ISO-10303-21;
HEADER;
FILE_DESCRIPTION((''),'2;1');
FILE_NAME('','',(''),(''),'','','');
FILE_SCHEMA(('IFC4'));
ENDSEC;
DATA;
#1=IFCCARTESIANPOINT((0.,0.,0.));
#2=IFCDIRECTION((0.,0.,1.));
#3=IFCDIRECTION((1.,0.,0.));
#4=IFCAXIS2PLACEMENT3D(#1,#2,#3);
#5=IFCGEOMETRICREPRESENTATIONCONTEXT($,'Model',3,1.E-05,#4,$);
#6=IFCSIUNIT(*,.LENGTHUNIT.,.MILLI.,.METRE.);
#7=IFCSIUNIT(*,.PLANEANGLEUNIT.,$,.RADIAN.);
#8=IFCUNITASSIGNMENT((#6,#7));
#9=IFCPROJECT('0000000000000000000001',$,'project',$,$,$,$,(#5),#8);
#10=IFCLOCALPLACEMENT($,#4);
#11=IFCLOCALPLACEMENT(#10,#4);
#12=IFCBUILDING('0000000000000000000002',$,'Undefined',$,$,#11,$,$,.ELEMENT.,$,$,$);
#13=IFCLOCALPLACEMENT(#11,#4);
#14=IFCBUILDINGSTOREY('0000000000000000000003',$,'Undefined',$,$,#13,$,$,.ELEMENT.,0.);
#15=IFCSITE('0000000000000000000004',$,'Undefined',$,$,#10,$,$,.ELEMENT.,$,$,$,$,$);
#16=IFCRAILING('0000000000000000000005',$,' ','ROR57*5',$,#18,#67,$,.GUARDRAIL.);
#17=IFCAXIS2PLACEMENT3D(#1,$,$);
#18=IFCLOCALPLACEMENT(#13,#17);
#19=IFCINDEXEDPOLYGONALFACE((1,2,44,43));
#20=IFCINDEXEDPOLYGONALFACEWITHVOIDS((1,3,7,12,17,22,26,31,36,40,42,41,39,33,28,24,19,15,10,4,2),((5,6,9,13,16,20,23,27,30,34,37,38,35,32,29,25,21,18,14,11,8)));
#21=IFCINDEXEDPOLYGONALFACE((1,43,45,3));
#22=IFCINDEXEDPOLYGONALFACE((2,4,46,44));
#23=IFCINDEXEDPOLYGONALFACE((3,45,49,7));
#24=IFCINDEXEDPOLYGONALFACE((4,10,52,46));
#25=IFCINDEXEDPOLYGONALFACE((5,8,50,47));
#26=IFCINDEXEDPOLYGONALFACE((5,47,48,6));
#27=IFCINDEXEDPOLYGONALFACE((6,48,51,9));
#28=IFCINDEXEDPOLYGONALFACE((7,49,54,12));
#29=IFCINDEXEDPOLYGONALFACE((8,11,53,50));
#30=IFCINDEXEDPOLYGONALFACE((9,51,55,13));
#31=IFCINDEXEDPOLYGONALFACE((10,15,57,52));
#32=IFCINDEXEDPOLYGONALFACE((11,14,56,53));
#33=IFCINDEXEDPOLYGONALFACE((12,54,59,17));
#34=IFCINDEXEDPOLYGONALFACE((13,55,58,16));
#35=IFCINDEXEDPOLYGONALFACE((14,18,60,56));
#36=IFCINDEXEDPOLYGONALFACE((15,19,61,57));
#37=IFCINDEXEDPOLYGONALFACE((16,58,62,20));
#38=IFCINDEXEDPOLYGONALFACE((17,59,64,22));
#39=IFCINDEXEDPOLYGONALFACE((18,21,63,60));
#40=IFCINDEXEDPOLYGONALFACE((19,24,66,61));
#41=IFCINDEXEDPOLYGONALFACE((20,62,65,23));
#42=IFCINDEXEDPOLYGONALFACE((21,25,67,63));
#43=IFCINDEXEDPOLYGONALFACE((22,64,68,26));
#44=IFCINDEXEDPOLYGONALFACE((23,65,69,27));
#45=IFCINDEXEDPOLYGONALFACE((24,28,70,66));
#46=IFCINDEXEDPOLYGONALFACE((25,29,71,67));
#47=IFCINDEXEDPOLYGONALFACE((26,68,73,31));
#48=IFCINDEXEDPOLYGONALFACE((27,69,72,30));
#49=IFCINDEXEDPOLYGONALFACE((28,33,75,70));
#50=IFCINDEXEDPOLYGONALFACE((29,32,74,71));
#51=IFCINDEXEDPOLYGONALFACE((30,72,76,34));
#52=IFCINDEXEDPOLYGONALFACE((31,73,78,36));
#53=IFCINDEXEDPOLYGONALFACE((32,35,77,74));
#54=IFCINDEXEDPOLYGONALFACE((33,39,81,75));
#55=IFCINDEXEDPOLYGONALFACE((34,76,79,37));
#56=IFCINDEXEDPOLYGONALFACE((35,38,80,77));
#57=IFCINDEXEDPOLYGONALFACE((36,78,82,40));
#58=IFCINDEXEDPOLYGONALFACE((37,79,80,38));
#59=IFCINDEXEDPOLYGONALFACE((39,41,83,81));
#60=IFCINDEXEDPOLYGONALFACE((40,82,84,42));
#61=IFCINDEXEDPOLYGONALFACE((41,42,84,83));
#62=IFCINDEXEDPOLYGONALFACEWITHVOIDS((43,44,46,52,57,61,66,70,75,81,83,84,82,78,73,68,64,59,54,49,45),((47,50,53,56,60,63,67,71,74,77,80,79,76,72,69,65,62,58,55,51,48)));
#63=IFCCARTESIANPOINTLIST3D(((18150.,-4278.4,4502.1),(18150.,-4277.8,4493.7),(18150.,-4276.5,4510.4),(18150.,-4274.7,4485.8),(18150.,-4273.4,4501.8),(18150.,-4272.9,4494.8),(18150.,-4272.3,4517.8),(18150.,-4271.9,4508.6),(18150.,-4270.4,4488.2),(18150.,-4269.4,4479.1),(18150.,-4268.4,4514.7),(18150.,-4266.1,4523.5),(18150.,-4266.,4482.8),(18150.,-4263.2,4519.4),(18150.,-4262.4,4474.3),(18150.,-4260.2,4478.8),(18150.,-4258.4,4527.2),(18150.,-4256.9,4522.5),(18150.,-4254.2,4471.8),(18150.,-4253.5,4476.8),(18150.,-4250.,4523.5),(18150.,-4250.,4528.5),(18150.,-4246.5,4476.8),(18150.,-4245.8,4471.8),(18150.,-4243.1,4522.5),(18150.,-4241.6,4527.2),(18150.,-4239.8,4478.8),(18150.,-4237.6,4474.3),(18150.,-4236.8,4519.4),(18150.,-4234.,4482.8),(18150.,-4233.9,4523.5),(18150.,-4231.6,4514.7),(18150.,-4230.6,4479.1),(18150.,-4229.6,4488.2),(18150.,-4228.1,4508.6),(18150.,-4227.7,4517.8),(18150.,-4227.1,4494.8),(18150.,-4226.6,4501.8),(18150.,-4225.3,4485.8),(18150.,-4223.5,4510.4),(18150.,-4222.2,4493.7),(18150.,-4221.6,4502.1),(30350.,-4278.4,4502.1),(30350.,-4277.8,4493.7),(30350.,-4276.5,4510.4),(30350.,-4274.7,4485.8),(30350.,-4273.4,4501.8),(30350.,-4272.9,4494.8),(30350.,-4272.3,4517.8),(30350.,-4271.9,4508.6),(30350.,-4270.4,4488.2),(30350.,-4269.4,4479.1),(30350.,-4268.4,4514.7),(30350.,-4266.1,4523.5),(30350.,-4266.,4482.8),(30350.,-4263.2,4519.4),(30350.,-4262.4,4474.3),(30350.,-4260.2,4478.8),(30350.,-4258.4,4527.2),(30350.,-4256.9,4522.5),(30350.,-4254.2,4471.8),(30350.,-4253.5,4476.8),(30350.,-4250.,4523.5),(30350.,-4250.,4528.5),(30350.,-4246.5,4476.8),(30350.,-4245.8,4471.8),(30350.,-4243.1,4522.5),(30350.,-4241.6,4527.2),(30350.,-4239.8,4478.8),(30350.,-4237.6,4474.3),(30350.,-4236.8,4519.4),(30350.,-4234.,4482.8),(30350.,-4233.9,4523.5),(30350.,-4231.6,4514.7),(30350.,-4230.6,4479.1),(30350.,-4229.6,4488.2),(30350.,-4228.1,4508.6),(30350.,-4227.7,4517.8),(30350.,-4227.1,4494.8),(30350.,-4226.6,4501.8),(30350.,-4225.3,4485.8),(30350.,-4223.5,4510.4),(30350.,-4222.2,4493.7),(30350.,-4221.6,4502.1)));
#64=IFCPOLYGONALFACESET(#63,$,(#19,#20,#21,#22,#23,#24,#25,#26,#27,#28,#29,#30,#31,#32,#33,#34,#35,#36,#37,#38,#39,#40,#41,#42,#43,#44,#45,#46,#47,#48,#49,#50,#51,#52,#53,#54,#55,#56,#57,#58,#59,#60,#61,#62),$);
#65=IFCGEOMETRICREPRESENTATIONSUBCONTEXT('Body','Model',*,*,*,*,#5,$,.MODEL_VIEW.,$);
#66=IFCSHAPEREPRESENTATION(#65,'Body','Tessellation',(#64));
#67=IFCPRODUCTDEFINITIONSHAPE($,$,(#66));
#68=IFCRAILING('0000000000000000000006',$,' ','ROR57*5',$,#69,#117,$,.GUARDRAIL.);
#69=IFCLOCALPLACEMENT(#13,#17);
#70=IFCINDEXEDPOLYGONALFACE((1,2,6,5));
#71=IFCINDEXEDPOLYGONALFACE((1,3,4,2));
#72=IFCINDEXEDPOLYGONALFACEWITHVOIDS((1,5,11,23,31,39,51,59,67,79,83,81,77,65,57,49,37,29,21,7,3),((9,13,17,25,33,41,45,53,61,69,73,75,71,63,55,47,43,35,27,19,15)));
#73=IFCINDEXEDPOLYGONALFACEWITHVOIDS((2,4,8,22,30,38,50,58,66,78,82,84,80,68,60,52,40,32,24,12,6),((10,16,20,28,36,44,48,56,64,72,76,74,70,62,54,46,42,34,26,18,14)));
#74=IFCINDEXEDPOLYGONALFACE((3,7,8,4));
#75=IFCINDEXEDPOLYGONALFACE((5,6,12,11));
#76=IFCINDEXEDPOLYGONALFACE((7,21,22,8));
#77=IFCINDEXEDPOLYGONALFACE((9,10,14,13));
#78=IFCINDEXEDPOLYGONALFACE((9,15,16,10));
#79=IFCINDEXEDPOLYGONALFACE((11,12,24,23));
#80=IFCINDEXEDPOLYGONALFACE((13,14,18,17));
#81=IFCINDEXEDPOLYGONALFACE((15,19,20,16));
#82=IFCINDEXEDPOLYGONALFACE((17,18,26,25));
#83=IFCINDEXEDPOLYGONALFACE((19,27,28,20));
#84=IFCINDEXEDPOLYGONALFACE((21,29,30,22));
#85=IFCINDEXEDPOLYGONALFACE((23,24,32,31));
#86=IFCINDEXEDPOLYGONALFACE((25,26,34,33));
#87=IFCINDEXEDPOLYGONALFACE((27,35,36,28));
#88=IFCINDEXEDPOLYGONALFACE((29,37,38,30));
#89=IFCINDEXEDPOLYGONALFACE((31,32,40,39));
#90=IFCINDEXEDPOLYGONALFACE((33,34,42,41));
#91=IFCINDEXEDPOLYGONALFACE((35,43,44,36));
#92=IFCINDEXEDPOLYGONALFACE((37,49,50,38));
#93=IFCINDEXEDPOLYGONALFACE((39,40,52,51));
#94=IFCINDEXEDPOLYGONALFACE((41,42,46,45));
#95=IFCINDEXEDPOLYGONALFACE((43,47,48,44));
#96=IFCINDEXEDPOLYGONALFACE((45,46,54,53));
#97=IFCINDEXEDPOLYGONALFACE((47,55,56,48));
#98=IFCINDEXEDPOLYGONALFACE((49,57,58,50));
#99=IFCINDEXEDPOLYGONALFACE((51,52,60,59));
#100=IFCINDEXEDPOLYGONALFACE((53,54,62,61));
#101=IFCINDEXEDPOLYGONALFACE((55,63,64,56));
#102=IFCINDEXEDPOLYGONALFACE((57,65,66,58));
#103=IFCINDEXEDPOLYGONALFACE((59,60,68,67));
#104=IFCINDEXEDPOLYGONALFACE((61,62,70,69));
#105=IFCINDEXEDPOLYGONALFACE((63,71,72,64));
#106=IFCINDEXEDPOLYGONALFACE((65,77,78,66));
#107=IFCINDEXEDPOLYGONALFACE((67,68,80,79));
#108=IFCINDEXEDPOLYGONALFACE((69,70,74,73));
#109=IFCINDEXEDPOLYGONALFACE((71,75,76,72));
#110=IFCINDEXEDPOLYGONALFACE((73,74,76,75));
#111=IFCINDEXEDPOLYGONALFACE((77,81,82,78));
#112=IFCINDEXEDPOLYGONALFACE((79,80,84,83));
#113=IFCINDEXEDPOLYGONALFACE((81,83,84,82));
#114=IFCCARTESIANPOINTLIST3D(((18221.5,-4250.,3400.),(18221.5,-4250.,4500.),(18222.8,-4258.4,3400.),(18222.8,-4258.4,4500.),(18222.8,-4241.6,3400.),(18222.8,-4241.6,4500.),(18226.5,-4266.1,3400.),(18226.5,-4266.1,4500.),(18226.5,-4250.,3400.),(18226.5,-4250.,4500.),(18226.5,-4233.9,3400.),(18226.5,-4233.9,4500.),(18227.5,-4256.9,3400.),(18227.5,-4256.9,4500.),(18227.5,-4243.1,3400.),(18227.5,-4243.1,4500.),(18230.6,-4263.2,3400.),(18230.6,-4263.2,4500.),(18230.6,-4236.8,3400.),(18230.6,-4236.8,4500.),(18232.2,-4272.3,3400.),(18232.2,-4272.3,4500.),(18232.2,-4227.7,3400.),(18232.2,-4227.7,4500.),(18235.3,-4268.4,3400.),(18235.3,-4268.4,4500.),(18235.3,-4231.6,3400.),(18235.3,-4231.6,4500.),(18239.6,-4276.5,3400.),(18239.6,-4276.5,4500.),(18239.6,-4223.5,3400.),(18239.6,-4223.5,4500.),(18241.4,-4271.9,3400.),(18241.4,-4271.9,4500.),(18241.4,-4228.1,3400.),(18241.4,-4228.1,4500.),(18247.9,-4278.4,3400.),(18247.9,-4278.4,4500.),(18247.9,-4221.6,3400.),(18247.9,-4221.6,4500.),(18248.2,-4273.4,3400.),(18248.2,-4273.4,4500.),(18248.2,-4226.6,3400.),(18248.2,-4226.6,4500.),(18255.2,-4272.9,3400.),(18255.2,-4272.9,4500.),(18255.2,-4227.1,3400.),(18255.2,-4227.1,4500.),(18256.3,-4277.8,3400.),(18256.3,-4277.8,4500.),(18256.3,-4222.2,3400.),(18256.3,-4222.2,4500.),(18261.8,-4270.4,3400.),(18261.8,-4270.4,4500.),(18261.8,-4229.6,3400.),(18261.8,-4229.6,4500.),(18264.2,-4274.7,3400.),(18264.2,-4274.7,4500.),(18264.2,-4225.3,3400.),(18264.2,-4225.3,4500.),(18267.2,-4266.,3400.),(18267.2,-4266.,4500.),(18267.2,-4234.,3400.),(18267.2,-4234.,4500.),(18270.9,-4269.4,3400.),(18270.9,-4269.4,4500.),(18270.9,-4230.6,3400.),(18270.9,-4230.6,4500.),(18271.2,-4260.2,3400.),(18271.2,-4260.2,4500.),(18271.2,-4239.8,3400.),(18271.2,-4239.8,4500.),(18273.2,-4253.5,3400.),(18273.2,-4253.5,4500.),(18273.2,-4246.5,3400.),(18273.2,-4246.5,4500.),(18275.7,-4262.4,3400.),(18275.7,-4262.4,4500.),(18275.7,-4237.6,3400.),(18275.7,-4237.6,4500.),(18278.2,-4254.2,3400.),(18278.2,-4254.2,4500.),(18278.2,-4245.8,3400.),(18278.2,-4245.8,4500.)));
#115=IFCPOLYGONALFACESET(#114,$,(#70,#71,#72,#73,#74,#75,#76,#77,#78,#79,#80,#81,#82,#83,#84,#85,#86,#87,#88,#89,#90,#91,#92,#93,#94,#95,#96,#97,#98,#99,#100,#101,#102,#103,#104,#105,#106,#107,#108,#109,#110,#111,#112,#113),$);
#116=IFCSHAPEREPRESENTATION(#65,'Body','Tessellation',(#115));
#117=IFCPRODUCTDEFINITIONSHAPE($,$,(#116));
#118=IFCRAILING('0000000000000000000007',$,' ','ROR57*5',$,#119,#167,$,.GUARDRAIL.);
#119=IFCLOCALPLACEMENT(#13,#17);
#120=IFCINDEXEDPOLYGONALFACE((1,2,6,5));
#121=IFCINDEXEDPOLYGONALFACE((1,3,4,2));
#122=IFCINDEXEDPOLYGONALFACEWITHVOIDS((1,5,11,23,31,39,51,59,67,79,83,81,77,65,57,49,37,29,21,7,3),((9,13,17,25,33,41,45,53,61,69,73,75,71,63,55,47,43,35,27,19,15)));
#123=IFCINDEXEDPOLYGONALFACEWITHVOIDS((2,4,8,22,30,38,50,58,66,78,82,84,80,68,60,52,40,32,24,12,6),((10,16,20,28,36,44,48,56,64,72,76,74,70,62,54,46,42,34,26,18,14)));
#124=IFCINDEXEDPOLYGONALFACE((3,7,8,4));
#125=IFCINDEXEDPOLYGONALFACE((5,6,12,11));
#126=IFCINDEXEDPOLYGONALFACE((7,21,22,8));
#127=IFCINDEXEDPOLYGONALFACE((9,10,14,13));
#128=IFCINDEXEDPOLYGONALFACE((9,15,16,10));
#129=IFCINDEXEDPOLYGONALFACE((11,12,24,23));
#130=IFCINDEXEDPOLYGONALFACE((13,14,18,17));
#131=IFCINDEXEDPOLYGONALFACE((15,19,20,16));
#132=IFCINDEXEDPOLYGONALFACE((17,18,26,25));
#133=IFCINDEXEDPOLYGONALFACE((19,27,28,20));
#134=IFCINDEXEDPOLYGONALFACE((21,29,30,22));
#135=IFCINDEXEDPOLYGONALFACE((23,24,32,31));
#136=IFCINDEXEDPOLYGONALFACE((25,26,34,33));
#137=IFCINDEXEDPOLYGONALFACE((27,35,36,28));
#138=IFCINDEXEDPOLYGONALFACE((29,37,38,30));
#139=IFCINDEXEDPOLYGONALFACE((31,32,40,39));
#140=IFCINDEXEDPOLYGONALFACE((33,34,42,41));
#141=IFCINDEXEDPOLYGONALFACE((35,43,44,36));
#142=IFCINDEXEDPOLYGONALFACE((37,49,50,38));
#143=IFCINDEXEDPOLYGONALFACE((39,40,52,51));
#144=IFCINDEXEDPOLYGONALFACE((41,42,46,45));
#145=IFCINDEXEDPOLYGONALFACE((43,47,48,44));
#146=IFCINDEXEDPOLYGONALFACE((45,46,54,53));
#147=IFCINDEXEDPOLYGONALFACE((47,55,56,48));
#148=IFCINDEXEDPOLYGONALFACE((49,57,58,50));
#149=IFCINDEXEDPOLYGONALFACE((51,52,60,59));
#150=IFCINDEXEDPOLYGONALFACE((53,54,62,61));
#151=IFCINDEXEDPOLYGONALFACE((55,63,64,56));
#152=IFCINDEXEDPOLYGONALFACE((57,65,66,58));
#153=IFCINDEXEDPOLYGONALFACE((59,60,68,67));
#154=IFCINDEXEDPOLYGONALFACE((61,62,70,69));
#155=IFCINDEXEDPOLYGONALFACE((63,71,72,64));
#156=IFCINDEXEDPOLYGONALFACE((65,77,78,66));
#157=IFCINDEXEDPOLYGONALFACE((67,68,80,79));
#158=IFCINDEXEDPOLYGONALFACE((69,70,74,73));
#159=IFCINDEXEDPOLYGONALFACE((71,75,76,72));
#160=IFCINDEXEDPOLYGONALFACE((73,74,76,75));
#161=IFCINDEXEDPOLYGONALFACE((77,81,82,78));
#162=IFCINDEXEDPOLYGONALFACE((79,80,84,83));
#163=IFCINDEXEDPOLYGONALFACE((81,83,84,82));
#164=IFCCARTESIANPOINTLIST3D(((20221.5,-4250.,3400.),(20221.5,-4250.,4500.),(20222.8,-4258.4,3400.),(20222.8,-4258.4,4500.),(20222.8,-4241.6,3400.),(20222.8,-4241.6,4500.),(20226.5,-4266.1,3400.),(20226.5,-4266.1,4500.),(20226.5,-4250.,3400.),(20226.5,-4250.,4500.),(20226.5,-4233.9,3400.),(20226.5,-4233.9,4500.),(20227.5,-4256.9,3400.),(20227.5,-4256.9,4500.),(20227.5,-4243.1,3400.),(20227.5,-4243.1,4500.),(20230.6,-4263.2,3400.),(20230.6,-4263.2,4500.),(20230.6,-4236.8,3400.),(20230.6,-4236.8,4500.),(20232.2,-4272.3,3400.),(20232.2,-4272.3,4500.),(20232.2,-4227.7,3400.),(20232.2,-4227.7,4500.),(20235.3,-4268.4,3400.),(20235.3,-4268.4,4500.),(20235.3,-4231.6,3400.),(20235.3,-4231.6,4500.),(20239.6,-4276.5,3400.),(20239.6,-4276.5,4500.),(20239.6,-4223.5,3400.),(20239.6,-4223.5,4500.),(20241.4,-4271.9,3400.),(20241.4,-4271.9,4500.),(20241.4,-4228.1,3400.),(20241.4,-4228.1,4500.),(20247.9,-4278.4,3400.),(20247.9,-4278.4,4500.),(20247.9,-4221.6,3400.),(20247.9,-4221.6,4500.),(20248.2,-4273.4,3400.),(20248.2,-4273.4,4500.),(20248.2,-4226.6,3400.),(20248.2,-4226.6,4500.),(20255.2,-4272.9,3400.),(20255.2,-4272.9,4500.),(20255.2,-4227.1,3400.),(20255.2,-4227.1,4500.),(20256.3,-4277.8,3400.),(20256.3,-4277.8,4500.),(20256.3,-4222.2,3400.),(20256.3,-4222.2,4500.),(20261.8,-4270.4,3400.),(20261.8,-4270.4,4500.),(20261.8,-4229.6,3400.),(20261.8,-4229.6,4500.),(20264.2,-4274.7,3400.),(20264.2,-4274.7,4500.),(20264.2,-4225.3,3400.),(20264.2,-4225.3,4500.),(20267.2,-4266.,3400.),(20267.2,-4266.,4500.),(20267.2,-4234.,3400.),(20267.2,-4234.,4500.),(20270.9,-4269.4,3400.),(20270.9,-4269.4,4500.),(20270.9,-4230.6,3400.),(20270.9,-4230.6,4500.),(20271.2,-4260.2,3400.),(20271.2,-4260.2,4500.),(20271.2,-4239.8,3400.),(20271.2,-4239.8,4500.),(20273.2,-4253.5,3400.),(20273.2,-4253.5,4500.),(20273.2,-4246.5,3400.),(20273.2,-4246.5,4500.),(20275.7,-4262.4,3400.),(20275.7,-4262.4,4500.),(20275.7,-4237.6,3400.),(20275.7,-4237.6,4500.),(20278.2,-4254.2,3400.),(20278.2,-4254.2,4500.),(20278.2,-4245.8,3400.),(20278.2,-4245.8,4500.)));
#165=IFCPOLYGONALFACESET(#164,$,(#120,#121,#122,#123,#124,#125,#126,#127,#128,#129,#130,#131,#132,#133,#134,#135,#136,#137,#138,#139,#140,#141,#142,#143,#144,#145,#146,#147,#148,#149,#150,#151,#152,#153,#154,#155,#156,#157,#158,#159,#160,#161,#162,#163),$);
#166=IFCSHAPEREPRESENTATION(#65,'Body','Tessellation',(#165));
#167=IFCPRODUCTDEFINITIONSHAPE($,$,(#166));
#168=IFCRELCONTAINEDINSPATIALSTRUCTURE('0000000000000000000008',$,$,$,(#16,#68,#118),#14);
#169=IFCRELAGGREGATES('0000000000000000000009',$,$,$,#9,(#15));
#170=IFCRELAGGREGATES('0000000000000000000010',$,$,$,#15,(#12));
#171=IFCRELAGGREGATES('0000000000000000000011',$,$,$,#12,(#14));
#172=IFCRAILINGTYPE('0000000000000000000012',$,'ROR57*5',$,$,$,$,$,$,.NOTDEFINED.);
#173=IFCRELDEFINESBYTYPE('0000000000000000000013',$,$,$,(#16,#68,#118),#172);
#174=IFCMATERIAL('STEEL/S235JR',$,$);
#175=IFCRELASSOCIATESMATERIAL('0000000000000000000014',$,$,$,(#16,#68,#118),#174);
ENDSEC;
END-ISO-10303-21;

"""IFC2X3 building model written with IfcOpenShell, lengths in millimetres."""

from ifc_helpers import new_model, si_unit, frame, origin_with_axes, origin_2d_with_axis, place, context, subcontext, project, spatial, hollow_circle, extrude, material, type_object, element, save


model = new_model("IFC2X3")

# Units and contexts
model_context = context("Model", 3, precision=1e-05, world=origin_with_axes())
body_context = subcontext(model_context, "Body", "Model", "MODEL_VIEW")
ifc_project = project(units=[si_unit("LENGTHUNIT", "METRE", prefix="MILLI"), si_unit("PLANEANGLEUNIT", "RADIAN")], contexts=[model_context])

# Site, building, storey
site_placement = place(None, origin_with_axes())
site = spatial("IfcSite", under=ifc_project, at=site_placement, Name="Undefined", CompositionType="ELEMENT")
building_placement = place(site_placement, origin_with_axes())
building = spatial("IfcBuilding", under=site, at=building_placement, Name="Undefined", CompositionType="ELEMENT")
storey_placement = place(building_placement, origin_with_axes())
storey = spatial("IfcBuildingStorey", under=building, at=storey_placement, Name="Undefined", CompositionType="ELEMENT", Elevation=0.0)

# Railings
ifc_material_1 = material(Name="STEEL/S235JR")
railing_type = type_object("IfcRailingType", Name="ROR57*5", PredefinedType="NOTDEFINED")
railing_1_placement = place(storey_placement, frame((30350.0, -4250.0, 4500.0), z_axis=(0.0, -1.0, 0.0), x_axis=(-1.0, 0.0, 0.0)))
element("IfcRailing", 1, at=railing_1_placement, inside=storey, type_object=railing_type, material=ifc_material_1, Name=" ", Description="ROR57*5", PredefinedType="GUARDRAIL", context=body_context, shape_type="SweptSolid", body=[
    extrude(hollow_circle(Radius=28.5, WallThickness=5.0, at=origin_2d_with_axis()), frame((12200.0, 0.0, 0.0), z_axis=(-1.0, 0.0, 0.0), x_axis=(0.0, -1.0, 0.0)), (0.0, 0.0, 1.0), 12200.0),
])
for number, where, z_axis, x_axis, name in (
    (2, (18250.0, -4250.0, 3400.0), (0.0, 1.0, 0.0), (0.0, 0.0, 1.0), " "),
    (3, (20250.0, -4250.0, 3400.0), (0.0, 1.0, 0.0), (0.0, 0.0, 1.0), " "),
):
    element("IfcRailing", number, at=place(storey_placement, frame(where, z_axis=z_axis, x_axis=x_axis)), inside=storey, type_object=railing_type, material=ifc_material_1, Name=name, Description="ROR57*5", PredefinedType="GUARDRAIL", context=body_context, shape_type="SweptSolid", body=[
        extrude(hollow_circle(Radius=28.5, WallThickness=5.0, at=origin_2d_with_axis()), frame((1100.0, 0.0, 0.0), z_axis=(-1.0, 0.0, 0.0), x_axis=(0.0, -1.0, 0.0)), (0.0, 0.0, 1.0), 1100.0),
    ])

save(model, "model.ifc")
